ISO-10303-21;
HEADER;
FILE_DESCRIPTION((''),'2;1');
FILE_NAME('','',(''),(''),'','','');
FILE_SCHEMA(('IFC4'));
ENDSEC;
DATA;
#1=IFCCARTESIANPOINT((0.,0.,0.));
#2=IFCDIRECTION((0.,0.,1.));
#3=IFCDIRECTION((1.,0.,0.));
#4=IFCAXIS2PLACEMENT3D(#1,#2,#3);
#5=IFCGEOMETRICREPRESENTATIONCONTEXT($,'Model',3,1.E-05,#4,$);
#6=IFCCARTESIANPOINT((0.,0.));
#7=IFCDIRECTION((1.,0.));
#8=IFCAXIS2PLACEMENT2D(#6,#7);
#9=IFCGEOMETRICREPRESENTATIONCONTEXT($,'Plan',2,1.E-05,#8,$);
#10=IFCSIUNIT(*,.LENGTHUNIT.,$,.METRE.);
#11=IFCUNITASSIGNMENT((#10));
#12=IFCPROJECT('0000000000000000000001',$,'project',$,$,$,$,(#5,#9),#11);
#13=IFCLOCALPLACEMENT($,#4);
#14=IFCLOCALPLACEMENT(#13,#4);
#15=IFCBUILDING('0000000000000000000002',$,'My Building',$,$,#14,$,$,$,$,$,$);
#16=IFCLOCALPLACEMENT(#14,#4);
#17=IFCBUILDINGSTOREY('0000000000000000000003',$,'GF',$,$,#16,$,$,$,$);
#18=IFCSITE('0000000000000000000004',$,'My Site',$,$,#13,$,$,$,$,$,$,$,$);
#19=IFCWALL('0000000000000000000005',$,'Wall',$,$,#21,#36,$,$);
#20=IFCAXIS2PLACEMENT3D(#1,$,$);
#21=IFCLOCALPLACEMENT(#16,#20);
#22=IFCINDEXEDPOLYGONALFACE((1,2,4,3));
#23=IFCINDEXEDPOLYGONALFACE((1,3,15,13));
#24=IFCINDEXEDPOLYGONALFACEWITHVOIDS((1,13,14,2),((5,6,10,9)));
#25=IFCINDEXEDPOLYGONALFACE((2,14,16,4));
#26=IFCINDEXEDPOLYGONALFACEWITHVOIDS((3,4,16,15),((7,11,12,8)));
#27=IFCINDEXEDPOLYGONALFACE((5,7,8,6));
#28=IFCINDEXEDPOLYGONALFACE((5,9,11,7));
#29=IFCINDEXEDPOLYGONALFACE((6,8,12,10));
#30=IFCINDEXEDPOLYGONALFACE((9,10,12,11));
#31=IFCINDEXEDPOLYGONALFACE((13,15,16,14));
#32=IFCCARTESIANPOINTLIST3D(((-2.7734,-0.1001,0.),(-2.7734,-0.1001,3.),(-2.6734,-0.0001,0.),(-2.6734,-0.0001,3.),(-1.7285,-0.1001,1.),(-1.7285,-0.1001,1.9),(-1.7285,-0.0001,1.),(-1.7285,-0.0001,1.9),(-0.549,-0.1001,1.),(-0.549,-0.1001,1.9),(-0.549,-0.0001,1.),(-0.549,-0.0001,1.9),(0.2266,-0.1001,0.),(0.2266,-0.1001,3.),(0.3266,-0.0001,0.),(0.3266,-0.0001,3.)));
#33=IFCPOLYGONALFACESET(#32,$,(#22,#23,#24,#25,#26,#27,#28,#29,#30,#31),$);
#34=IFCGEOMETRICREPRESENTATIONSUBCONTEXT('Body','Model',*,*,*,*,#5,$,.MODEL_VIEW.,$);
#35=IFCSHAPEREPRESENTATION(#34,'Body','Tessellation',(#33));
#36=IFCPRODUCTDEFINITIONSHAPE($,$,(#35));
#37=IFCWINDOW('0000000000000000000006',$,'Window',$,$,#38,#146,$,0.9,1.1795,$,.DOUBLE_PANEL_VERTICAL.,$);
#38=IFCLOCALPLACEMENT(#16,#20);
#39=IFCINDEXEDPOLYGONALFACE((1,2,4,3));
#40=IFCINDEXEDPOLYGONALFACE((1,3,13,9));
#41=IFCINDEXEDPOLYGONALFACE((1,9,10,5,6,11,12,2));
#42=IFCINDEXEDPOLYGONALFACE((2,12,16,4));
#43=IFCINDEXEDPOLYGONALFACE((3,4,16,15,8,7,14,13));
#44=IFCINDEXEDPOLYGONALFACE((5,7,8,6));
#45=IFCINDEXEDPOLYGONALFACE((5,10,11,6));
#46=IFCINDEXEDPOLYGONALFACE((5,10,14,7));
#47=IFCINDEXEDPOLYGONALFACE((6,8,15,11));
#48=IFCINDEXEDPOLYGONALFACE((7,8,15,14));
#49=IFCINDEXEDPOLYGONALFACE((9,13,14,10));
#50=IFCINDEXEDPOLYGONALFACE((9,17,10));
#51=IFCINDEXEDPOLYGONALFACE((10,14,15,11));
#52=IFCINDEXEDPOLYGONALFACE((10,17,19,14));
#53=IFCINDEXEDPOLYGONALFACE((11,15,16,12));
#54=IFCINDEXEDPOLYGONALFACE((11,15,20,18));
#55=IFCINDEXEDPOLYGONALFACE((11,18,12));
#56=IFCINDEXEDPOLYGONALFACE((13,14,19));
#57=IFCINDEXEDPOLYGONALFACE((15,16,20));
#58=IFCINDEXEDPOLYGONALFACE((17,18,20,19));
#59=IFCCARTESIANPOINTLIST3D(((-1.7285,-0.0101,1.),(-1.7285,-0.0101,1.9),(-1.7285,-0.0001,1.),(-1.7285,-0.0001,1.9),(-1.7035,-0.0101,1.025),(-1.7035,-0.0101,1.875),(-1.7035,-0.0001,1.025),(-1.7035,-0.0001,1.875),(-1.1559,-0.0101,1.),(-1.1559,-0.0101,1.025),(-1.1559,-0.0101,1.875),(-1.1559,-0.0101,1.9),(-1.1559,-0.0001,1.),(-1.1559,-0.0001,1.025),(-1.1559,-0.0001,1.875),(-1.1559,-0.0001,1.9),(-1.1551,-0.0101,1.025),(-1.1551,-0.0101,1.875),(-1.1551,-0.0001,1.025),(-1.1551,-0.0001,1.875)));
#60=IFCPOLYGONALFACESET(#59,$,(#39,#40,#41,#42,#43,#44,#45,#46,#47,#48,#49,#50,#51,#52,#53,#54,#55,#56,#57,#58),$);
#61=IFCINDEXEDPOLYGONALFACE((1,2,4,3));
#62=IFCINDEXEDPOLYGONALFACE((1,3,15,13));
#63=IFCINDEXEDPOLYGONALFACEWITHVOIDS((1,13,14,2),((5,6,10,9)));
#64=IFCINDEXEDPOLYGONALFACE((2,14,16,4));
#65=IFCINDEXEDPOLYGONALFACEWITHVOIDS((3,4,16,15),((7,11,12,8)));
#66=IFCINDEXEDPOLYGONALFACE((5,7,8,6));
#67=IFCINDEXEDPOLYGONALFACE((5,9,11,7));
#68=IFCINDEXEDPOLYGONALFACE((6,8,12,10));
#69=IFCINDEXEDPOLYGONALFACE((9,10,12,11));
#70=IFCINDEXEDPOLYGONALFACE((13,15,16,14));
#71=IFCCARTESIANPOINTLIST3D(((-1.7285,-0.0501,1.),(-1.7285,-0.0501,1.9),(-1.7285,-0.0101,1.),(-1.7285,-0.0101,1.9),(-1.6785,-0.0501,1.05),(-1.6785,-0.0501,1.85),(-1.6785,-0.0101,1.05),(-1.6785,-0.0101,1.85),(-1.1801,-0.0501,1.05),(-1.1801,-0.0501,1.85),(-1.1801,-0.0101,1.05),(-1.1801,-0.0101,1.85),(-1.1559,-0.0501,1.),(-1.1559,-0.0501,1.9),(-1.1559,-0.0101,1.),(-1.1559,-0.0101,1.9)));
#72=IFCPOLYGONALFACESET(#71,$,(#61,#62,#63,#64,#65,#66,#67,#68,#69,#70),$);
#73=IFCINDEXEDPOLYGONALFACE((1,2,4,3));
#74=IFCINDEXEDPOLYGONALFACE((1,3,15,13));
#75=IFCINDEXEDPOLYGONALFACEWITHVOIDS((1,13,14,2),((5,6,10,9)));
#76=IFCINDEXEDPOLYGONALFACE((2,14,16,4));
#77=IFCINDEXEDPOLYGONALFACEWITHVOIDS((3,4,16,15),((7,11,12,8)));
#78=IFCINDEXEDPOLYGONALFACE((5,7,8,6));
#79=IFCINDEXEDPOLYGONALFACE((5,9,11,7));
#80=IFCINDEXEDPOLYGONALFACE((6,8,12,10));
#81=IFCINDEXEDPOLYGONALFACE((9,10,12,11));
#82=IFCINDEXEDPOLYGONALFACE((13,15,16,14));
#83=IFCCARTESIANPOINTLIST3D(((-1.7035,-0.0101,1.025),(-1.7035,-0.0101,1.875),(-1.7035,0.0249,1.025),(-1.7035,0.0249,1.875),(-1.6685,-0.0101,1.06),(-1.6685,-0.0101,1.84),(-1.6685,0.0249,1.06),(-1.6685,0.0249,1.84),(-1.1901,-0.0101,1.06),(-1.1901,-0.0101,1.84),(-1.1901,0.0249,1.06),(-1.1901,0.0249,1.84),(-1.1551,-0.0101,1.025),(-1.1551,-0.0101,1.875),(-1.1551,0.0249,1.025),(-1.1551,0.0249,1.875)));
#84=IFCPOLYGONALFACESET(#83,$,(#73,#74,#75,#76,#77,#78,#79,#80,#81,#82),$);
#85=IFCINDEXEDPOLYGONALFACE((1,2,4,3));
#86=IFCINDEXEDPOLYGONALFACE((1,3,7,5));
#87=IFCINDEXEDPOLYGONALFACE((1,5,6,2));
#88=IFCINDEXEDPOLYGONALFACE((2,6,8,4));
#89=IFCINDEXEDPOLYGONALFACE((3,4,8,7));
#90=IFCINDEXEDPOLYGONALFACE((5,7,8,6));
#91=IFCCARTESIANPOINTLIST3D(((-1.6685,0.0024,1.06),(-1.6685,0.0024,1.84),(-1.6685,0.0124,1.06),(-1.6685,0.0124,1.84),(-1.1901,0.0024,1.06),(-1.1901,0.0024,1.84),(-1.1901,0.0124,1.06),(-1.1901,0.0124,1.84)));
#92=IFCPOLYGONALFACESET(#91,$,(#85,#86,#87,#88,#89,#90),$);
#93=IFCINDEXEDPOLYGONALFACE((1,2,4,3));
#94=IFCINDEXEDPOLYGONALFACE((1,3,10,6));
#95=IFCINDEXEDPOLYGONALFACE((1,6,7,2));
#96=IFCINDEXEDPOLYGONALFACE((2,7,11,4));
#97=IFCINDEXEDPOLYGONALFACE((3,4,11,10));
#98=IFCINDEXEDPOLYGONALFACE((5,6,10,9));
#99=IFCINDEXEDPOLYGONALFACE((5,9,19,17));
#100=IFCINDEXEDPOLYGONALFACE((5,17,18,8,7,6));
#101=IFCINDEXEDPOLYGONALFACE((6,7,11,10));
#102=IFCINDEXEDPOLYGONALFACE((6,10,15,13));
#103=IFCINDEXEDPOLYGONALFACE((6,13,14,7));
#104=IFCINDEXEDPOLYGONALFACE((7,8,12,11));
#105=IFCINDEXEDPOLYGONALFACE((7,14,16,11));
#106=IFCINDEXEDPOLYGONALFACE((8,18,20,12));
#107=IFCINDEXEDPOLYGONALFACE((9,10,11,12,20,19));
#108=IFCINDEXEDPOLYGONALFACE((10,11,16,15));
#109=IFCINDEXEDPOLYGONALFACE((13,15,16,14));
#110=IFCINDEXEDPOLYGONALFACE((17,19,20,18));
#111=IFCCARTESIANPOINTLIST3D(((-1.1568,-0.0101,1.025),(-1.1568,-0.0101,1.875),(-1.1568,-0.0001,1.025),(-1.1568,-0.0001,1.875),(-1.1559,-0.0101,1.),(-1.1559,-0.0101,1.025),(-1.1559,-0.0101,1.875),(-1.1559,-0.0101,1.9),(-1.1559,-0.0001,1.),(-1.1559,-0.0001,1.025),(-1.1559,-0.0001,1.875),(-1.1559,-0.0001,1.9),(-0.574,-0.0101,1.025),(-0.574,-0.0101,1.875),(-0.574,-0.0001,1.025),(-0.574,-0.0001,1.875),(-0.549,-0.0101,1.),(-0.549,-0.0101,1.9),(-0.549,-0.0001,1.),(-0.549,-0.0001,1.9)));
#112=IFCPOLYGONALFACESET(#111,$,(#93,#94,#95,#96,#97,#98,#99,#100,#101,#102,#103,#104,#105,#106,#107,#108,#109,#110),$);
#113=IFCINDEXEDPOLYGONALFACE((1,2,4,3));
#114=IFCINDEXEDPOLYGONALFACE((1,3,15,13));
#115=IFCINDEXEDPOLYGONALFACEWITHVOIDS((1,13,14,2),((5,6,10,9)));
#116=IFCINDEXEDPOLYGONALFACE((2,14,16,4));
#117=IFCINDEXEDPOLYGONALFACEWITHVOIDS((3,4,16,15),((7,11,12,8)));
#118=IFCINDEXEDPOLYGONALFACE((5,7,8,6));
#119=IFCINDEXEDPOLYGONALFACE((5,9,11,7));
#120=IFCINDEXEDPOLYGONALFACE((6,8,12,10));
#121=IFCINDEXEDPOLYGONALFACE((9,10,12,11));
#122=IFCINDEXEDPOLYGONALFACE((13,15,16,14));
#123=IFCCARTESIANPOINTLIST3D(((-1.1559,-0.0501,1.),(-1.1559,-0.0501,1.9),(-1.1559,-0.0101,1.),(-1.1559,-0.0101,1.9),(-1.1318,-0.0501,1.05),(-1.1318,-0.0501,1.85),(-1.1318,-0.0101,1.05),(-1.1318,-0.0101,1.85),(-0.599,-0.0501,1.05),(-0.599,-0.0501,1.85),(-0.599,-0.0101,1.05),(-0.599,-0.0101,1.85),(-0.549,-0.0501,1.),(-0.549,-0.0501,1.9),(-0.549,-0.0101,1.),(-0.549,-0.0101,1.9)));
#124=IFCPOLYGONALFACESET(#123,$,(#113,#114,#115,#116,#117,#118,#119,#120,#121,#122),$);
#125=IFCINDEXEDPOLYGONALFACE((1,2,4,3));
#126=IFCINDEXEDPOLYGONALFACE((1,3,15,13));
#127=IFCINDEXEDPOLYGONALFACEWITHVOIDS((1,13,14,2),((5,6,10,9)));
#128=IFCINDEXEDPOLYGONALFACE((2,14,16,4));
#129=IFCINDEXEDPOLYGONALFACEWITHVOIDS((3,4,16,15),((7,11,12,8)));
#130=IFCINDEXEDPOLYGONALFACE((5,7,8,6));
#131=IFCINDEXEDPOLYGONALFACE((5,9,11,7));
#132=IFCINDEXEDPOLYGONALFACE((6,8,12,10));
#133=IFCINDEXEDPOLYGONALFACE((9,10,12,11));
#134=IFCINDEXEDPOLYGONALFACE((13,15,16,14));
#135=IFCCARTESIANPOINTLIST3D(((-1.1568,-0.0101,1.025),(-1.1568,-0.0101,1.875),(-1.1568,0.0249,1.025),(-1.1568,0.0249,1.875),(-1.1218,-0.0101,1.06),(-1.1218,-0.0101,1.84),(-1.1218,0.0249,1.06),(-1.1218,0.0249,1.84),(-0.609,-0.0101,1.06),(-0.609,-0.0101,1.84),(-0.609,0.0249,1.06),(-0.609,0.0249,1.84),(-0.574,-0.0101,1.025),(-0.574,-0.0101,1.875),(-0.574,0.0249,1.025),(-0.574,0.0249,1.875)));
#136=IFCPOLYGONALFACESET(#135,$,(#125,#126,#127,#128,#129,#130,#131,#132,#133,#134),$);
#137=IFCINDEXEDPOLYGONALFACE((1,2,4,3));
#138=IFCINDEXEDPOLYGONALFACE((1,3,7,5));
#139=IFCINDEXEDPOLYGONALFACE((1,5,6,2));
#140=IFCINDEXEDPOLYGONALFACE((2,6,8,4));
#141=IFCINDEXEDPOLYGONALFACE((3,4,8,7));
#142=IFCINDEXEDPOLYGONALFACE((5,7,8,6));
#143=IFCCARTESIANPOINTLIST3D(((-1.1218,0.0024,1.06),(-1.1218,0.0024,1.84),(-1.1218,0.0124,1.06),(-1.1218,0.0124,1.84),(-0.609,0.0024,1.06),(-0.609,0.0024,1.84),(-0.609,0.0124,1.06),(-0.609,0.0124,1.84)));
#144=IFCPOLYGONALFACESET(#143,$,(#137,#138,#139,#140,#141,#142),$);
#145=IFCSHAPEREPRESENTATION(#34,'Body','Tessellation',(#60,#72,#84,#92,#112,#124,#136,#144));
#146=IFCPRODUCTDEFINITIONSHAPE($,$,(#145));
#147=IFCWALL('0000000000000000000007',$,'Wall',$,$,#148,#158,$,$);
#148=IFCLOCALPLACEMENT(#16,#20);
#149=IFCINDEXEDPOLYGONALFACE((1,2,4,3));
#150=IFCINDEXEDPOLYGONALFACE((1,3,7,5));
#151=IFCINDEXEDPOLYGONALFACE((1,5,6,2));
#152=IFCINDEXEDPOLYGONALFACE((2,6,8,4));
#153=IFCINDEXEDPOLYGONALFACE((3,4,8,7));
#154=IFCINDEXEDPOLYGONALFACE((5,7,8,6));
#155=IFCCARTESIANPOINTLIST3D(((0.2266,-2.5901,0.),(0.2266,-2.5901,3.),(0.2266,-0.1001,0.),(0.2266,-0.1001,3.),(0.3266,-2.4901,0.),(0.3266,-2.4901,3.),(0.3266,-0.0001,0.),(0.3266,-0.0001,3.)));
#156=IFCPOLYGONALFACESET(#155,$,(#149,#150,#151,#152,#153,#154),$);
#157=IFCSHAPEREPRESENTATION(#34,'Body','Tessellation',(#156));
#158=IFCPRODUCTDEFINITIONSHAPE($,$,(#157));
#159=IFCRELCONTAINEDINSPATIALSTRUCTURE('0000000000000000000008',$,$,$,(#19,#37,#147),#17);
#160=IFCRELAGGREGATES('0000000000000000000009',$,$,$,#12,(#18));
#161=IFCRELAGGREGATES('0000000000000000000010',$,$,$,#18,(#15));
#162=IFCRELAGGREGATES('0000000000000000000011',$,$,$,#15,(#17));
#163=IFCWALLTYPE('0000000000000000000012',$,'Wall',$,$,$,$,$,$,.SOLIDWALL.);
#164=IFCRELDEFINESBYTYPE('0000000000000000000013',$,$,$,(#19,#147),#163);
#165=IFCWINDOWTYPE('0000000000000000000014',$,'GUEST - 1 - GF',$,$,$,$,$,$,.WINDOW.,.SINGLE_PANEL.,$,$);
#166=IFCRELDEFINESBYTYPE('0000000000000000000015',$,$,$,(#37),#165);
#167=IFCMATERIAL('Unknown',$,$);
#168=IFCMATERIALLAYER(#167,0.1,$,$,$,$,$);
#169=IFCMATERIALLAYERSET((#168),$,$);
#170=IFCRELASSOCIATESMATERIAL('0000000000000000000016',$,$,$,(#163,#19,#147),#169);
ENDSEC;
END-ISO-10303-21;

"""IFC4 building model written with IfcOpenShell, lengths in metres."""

from ifc_helpers import new_model, entity, si_unit, frame, origin_with_axes, origin_2d_with_axis, place, context, subcontext, project, spatial, line, indexed_curve, outline, extrude, shape, source, transform, mapped, material, layer, layer_set, layer_usage, type_object, type_shapes, element, fill, save


model = new_model("IFC4")

# Units and contexts
model_context = context("Model", 3, precision=1e-05, world=origin_with_axes())
plan_context = context("Plan", 2, precision=1e-05, world=origin_2d_with_axis())
body_context_1 = subcontext(model_context, "Body", "Model", "MODEL_VIEW")
body_context_2 = subcontext(plan_context, "Body", "Plan", "PLAN_VIEW")
ifc_project = project(units=[si_unit("LENGTHUNIT", "METRE")], contexts=[model_context, plan_context])

# Site, building, storey
site_placement = place(None, origin_with_axes())
site = spatial("IfcSite", under=ifc_project, at=site_placement, Name="My Site")
building_placement = place(site_placement, origin_with_axes())
building = spatial("IfcBuilding", under=site, at=building_placement, Name="My Building")
storey_placement = place(building_placement, origin_with_axes())
storey = spatial("IfcBuildingStorey", under=building, at=storey_placement, Name="GF")

# Shared definitions
ifc_material = material(Name="Unknown")

# Shared definitions
ifc_layer_1 = layer(ifc_material, 0.1)
ifc_layer_set_1 = layer_set([ifc_layer_1])
wall_type = type_object("IfcWallType", Name="Wall", PredefinedType="SOLIDWALL", material=ifc_layer_set_1)

# Wall, opening, window
ifc_layer_usage_1 = layer_usage(ifc_layer_set_1, "AXIS2", "POSITIVE", 0.0)
wall_1_placement = place(storey_placement, frame((-2.7734, -0.1001, 0.0), z_axis=(0.0, 0.0, 1.0), x_axis=(1.0, 0.0, 0.0)))
wall_1 = element("IfcWall", 1, at=wall_1_placement, inside=storey, type_object=wall_type, material=ifc_layer_usage_1, Name="Wall", context=body_context_1, shape_type="SweptSolid", body=[
    extrude(outline(indexed_curve([(0.0, 0.0), (0.1, 0.1), (3.1, 0.1), (3.0, 0.0)], segments=[line(1, 2, 3, 4, 1)])), origin_with_axes(), (0.0, 0.0, 1.0), 3.0),
])
shared_shape_1 = source(origin_with_axes(), body_context_1, "Body", "SweptSolid", [
    extrude(outline(indexed_curve([(0.0, 0.0), (1.1795, 0.0), (1.1795, 0.9), (0.0, 0.9)], segments=[line(1, 2, 3, 4, 1)])), frame((0.0, -0.6, 0.0), z_axis=(0.0, -1.0, 0.0), x_axis=(1.0, 0.0, 0.0)), (0.0, 0.0, -1.0), 1.2),
])
opening_1_placement = place(wall_1_placement, frame((1.0449, 0.0, 1.0), z_axis=(0.0, 0.0, 1.0), x_axis=(1.0, 0.0, 0.0)))
opening_1 = element("IfcOpeningElement", 2, at=opening_1_placement, cuts=wall_1, PredefinedType="OPENING", context=body_context_1, shape_type="MappedRepresentation", body=[
    mapped(shared_shape_1, transform((0.0, 0.0, 0.0), x_axis=(1.0, 0.0, 0.0), y_axis=(0.0, 1.0, 0.0), z_axis=(0.0, 0.0, 1.0), scale=1.0)),
])
window_type_1 = type_object("IfcWindowType", Name="GUEST - 1 - GF", PartitioningType="SINGLE_PANEL", PredefinedType="WINDOW")
shared_shape_2 = source(origin_with_axes(), body_context_1, "Body", "SweptSolid", [
    extrude(outline(indexed_curve([(0.0, 0.0), (0.5726, 0.0), (0.5726, 0.9), (0.0, 0.9)], segments=[line(1, 2, 3, 4, 1)]), holes=[indexed_curve([(0.025, 0.025), (0.5735, 0.025), (0.5735, 0.875), (0.025, 0.875)], segments=[line(1, 2, 3, 4, 1)])]), frame((0.0, 0.09, 0.0), z_axis=(0.0, -1.0, 0.0), x_axis=(1.0, 0.0, 0.0)), (0.0, 0.0, -1.0), 0.01),
    extrude(outline(indexed_curve([(0.0, 0.0), (0.5726, 0.0), (0.5726, 0.9), (0.0, 0.9)], segments=[line(1, 2, 3, 4, 1)]), holes=[indexed_curve([(0.05, 0.05), (0.5485, 0.05), (0.5485, 0.85), (0.05, 0.85)], segments=[line(1, 2, 3, 4, 1)])]), frame((0.0, 0.05, 0.0), z_axis=(0.0, -1.0, 0.0), x_axis=(1.0, 0.0, 0.0)), (0.0, 0.0, -1.0), 0.04),
    extrude(outline(indexed_curve([(0.0, 0.0), (0.5485, 0.0), (0.5485, 0.85), (0.0, 0.85)], segments=[line(1, 2, 3, 4, 1)]), holes=[indexed_curve([(0.035, 0.035), (0.5135, 0.035), (0.5135, 0.815), (0.035, 0.815)], segments=[line(1, 2, 3, 4, 1)])]), frame((0.025, 0.09, 0.025), z_axis=(0.0, -1.0, 0.0), x_axis=(1.0, 0.0, 0.0)), (0.0, 0.0, -1.0), 0.035),
    extrude(outline(indexed_curve([(0.035, 0.035), (0.5135, 0.035), (0.5135, 0.815), (0.035, 0.815)], segments=[line(1, 2, 3, 4, 1)])), frame((0.025, 0.1025, 0.025), z_axis=(0.0, -1.0, 0.0), x_axis=(1.0, 0.0, 0.0)), (0.0, 0.0, -1.0), 0.01),
    extrude(outline(indexed_curve([(0.0, 0.0), (0.607, 0.0), (0.607, 0.9), (0.0, 0.9)], segments=[line(1, 2, 3, 4, 1)]), holes=[indexed_curve([(-0.0009, 0.025), (0.582, 0.025), (0.582, 0.875), (-0.0009, 0.875)], segments=[line(1, 2, 3, 4, 1)])]), frame((0.5726, 0.09, 0.0), z_axis=(0.0, -1.0, 0.0), x_axis=(1.0, 0.0, 0.0)), (0.0, 0.0, -1.0), 0.01),
    extrude(outline(indexed_curve([(0.0, 0.0), (0.607, 0.0), (0.607, 0.9), (0.0, 0.9)], segments=[line(1, 2, 3, 4, 1)]), holes=[indexed_curve([(0.0241, 0.05), (0.557, 0.05), (0.557, 0.85), (0.0241, 0.85)], segments=[line(1, 2, 3, 4, 1)])]), frame((0.5726, 0.05, 0.0), z_axis=(0.0, -1.0, 0.0), x_axis=(1.0, 0.0, 0.0)), (0.0, 0.0, -1.0), 0.04),
    extrude(outline(indexed_curve([(0.0, 0.0), (0.5828, 0.0), (0.5828, 0.85), (0.0, 0.85)], segments=[line(1, 2, 3, 4, 1)]), holes=[indexed_curve([(0.035, 0.035), (0.5478, 0.035), (0.5478, 0.815), (0.035, 0.815)], segments=[line(1, 2, 3, 4, 1)])]), frame((0.5717, 0.09, 0.025), z_axis=(0.0, -1.0, 0.0), x_axis=(1.0, 0.0, 0.0)), (0.0, 0.0, -1.0), 0.035),
    extrude(outline(indexed_curve([(0.035, 0.035), (0.5478, 0.035), (0.5478, 0.815), (0.035, 0.815)], segments=[line(1, 2, 3, 4, 1)])), frame((0.5717, 0.1025, 0.025), z_axis=(0.0, -1.0, 0.0), x_axis=(1.0, 0.0, 0.0)), (0.0, 0.0, -1.0), 0.01),
])
shared_shape_3 = source(origin_with_axes(), body_context_2, "Body", "Curve2D", [
    entity("IfcIndexedPolyCurve", entity("IfcCartesianPointList2D", [[0.05, 0.05], [0.5485, 0.05]])),
    entity("IfcIndexedPolyCurve", entity("IfcCartesianPointList2D", [[0.0, 0.1], [0.025, 0.1], [0.025, 0.09], [0.05, 0.09], [0.05, 0.05], [0.0, 0.05]]), [entity("IfcLineIndex", [1, 2, 3, 4, 5, 6, 1])]),
    entity("IfcIndexedPolyCurve", entity("IfcCartesianPointList2D", [[0.5726, 0.1], [0.5735, 0.1], [0.5735, 0.09], [0.5485, 0.09], [0.5485, 0.05], [0.5726, 0.05]])),
    entity("IfcIndexedPolyCurve", entity("IfcCartesianPointList2D", [[0.025, 0.09], [0.06, 0.09], [0.06, 0.125], [0.025, 0.125]]), [entity("IfcLineIndex", [1, 2, 3, 4, 1])]),
    entity("IfcIndexedPolyCurve", entity("IfcCartesianPointList2D", [[0.5735, 0.09], [0.5385, 0.09], [0.5385, 0.125], [0.5735, 0.125]]), [entity("IfcLineIndex", [1, 2, 3, 4, 1])]),
    entity("IfcIndexedPolyCurve", entity("IfcCartesianPointList2D", [[0.06, 0.09], [0.5385, 0.09]])),
    entity("IfcIndexedPolyCurve", entity("IfcCartesianPointList2D", [[0.06, 0.125], [0.5385, 0.125]])),
    entity("IfcIndexedPolyCurve", entity("IfcCartesianPointList2D", [[0.06, 0.1075], [0.5385, 0.1075]])),
    entity("IfcIndexedPolyCurve", entity("IfcCartesianPointList2D", [[0.5967, 0.05], [1.1295, 0.05]])),
    entity("IfcIndexedPolyCurve", entity("IfcCartesianPointList2D", [[0.5726, 0.1], [0.5717, 0.1], [0.5717, 0.09], [0.5967, 0.09], [0.5967, 0.05], [0.5726, 0.05]])),
    entity("IfcIndexedPolyCurve", entity("IfcCartesianPointList2D", [[1.1795, 0.1], [1.1545, 0.1], [1.1545, 0.09], [1.1295, 0.09], [1.1295, 0.05], [1.1795, 0.05]]), [entity("IfcLineIndex", [1, 2, 3, 4, 5, 6, 1])]),
    entity("IfcIndexedPolyCurve", entity("IfcCartesianPointList2D", [[0.5717, 0.09], [0.6067, 0.09], [0.6067, 0.125], [0.5717, 0.125]]), [entity("IfcLineIndex", [1, 2, 3, 4, 1])]),
    entity("IfcIndexedPolyCurve", entity("IfcCartesianPointList2D", [[1.1545, 0.09], [1.1195, 0.09], [1.1195, 0.125], [1.1545, 0.125]]), [entity("IfcLineIndex", [1, 2, 3, 4, 1])]),
    entity("IfcIndexedPolyCurve", entity("IfcCartesianPointList2D", [[0.6067, 0.09], [1.1195, 0.09]])),
    entity("IfcIndexedPolyCurve", entity("IfcCartesianPointList2D", [[0.6067, 0.125], [1.1195, 0.125]])),
    entity("IfcIndexedPolyCurve", entity("IfcCartesianPointList2D", [[0.6067, 0.1075], [1.1195, 0.1075]])),
])
type_shapes(window_type_1, [shared_shape_2, shared_shape_3])
window_1_placement = place(opening_1_placement, origin_with_axes())
window_1 = element("IfcWindow", 3, at=window_1_placement, inside=storey, type_object=window_type_1, Name="Window", OverallHeight=0.9, OverallWidth=1.1795, PartitioningType="DOUBLE_PANEL_VERTICAL", shapes=[
    shape(body_context_1, "Body", "MappedRepresentation", [mapped(shared_shape_2, transform((0.0, 0.0, 0.0), x_axis=(1.0, 0.0, 0.0), y_axis=(0.0, 1.0, 0.0), z_axis=(0.0, 0.0, 1.0), scale=1.0))]),
    shape(body_context_2, "Body", "MappedRepresentation", [mapped(shared_shape_3, transform((0.0, 0.0, 0.0), x_axis=(1.0, 0.0, 0.0), y_axis=(0.0, 1.0, 0.0), z_axis=(0.0, 0.0, 1.0), scale=1.0))]),
])
fill(opening_1, window_1)

# Wall
ifc_layer_usage_2 = layer_usage(ifc_layer_set_1, "AXIS2", "POSITIVE", 0.0)
wall_2_placement = place(storey_placement, frame((0.2266, -0.1001, 0.0), z_axis=(0.0, 0.0, 1.0), x_axis=(0.000001, -1.0, 0.0)))
element("IfcWall", 4, at=wall_2_placement, inside=storey, type_object=wall_type, material=ifc_layer_usage_2, Name="Wall", context=body_context_1, shape_type="SweptSolid", body=[
    extrude(outline(indexed_curve([(0.0, 0.0), (-0.1, 0.1), (2.39, 0.1), (2.49, 0.0)], segments=[line(1, 2, 3, 4, 1)])), origin_with_axes(), (0.0, 0.0, 1.0), 3.0),
])

save(model, "model.ifc")
